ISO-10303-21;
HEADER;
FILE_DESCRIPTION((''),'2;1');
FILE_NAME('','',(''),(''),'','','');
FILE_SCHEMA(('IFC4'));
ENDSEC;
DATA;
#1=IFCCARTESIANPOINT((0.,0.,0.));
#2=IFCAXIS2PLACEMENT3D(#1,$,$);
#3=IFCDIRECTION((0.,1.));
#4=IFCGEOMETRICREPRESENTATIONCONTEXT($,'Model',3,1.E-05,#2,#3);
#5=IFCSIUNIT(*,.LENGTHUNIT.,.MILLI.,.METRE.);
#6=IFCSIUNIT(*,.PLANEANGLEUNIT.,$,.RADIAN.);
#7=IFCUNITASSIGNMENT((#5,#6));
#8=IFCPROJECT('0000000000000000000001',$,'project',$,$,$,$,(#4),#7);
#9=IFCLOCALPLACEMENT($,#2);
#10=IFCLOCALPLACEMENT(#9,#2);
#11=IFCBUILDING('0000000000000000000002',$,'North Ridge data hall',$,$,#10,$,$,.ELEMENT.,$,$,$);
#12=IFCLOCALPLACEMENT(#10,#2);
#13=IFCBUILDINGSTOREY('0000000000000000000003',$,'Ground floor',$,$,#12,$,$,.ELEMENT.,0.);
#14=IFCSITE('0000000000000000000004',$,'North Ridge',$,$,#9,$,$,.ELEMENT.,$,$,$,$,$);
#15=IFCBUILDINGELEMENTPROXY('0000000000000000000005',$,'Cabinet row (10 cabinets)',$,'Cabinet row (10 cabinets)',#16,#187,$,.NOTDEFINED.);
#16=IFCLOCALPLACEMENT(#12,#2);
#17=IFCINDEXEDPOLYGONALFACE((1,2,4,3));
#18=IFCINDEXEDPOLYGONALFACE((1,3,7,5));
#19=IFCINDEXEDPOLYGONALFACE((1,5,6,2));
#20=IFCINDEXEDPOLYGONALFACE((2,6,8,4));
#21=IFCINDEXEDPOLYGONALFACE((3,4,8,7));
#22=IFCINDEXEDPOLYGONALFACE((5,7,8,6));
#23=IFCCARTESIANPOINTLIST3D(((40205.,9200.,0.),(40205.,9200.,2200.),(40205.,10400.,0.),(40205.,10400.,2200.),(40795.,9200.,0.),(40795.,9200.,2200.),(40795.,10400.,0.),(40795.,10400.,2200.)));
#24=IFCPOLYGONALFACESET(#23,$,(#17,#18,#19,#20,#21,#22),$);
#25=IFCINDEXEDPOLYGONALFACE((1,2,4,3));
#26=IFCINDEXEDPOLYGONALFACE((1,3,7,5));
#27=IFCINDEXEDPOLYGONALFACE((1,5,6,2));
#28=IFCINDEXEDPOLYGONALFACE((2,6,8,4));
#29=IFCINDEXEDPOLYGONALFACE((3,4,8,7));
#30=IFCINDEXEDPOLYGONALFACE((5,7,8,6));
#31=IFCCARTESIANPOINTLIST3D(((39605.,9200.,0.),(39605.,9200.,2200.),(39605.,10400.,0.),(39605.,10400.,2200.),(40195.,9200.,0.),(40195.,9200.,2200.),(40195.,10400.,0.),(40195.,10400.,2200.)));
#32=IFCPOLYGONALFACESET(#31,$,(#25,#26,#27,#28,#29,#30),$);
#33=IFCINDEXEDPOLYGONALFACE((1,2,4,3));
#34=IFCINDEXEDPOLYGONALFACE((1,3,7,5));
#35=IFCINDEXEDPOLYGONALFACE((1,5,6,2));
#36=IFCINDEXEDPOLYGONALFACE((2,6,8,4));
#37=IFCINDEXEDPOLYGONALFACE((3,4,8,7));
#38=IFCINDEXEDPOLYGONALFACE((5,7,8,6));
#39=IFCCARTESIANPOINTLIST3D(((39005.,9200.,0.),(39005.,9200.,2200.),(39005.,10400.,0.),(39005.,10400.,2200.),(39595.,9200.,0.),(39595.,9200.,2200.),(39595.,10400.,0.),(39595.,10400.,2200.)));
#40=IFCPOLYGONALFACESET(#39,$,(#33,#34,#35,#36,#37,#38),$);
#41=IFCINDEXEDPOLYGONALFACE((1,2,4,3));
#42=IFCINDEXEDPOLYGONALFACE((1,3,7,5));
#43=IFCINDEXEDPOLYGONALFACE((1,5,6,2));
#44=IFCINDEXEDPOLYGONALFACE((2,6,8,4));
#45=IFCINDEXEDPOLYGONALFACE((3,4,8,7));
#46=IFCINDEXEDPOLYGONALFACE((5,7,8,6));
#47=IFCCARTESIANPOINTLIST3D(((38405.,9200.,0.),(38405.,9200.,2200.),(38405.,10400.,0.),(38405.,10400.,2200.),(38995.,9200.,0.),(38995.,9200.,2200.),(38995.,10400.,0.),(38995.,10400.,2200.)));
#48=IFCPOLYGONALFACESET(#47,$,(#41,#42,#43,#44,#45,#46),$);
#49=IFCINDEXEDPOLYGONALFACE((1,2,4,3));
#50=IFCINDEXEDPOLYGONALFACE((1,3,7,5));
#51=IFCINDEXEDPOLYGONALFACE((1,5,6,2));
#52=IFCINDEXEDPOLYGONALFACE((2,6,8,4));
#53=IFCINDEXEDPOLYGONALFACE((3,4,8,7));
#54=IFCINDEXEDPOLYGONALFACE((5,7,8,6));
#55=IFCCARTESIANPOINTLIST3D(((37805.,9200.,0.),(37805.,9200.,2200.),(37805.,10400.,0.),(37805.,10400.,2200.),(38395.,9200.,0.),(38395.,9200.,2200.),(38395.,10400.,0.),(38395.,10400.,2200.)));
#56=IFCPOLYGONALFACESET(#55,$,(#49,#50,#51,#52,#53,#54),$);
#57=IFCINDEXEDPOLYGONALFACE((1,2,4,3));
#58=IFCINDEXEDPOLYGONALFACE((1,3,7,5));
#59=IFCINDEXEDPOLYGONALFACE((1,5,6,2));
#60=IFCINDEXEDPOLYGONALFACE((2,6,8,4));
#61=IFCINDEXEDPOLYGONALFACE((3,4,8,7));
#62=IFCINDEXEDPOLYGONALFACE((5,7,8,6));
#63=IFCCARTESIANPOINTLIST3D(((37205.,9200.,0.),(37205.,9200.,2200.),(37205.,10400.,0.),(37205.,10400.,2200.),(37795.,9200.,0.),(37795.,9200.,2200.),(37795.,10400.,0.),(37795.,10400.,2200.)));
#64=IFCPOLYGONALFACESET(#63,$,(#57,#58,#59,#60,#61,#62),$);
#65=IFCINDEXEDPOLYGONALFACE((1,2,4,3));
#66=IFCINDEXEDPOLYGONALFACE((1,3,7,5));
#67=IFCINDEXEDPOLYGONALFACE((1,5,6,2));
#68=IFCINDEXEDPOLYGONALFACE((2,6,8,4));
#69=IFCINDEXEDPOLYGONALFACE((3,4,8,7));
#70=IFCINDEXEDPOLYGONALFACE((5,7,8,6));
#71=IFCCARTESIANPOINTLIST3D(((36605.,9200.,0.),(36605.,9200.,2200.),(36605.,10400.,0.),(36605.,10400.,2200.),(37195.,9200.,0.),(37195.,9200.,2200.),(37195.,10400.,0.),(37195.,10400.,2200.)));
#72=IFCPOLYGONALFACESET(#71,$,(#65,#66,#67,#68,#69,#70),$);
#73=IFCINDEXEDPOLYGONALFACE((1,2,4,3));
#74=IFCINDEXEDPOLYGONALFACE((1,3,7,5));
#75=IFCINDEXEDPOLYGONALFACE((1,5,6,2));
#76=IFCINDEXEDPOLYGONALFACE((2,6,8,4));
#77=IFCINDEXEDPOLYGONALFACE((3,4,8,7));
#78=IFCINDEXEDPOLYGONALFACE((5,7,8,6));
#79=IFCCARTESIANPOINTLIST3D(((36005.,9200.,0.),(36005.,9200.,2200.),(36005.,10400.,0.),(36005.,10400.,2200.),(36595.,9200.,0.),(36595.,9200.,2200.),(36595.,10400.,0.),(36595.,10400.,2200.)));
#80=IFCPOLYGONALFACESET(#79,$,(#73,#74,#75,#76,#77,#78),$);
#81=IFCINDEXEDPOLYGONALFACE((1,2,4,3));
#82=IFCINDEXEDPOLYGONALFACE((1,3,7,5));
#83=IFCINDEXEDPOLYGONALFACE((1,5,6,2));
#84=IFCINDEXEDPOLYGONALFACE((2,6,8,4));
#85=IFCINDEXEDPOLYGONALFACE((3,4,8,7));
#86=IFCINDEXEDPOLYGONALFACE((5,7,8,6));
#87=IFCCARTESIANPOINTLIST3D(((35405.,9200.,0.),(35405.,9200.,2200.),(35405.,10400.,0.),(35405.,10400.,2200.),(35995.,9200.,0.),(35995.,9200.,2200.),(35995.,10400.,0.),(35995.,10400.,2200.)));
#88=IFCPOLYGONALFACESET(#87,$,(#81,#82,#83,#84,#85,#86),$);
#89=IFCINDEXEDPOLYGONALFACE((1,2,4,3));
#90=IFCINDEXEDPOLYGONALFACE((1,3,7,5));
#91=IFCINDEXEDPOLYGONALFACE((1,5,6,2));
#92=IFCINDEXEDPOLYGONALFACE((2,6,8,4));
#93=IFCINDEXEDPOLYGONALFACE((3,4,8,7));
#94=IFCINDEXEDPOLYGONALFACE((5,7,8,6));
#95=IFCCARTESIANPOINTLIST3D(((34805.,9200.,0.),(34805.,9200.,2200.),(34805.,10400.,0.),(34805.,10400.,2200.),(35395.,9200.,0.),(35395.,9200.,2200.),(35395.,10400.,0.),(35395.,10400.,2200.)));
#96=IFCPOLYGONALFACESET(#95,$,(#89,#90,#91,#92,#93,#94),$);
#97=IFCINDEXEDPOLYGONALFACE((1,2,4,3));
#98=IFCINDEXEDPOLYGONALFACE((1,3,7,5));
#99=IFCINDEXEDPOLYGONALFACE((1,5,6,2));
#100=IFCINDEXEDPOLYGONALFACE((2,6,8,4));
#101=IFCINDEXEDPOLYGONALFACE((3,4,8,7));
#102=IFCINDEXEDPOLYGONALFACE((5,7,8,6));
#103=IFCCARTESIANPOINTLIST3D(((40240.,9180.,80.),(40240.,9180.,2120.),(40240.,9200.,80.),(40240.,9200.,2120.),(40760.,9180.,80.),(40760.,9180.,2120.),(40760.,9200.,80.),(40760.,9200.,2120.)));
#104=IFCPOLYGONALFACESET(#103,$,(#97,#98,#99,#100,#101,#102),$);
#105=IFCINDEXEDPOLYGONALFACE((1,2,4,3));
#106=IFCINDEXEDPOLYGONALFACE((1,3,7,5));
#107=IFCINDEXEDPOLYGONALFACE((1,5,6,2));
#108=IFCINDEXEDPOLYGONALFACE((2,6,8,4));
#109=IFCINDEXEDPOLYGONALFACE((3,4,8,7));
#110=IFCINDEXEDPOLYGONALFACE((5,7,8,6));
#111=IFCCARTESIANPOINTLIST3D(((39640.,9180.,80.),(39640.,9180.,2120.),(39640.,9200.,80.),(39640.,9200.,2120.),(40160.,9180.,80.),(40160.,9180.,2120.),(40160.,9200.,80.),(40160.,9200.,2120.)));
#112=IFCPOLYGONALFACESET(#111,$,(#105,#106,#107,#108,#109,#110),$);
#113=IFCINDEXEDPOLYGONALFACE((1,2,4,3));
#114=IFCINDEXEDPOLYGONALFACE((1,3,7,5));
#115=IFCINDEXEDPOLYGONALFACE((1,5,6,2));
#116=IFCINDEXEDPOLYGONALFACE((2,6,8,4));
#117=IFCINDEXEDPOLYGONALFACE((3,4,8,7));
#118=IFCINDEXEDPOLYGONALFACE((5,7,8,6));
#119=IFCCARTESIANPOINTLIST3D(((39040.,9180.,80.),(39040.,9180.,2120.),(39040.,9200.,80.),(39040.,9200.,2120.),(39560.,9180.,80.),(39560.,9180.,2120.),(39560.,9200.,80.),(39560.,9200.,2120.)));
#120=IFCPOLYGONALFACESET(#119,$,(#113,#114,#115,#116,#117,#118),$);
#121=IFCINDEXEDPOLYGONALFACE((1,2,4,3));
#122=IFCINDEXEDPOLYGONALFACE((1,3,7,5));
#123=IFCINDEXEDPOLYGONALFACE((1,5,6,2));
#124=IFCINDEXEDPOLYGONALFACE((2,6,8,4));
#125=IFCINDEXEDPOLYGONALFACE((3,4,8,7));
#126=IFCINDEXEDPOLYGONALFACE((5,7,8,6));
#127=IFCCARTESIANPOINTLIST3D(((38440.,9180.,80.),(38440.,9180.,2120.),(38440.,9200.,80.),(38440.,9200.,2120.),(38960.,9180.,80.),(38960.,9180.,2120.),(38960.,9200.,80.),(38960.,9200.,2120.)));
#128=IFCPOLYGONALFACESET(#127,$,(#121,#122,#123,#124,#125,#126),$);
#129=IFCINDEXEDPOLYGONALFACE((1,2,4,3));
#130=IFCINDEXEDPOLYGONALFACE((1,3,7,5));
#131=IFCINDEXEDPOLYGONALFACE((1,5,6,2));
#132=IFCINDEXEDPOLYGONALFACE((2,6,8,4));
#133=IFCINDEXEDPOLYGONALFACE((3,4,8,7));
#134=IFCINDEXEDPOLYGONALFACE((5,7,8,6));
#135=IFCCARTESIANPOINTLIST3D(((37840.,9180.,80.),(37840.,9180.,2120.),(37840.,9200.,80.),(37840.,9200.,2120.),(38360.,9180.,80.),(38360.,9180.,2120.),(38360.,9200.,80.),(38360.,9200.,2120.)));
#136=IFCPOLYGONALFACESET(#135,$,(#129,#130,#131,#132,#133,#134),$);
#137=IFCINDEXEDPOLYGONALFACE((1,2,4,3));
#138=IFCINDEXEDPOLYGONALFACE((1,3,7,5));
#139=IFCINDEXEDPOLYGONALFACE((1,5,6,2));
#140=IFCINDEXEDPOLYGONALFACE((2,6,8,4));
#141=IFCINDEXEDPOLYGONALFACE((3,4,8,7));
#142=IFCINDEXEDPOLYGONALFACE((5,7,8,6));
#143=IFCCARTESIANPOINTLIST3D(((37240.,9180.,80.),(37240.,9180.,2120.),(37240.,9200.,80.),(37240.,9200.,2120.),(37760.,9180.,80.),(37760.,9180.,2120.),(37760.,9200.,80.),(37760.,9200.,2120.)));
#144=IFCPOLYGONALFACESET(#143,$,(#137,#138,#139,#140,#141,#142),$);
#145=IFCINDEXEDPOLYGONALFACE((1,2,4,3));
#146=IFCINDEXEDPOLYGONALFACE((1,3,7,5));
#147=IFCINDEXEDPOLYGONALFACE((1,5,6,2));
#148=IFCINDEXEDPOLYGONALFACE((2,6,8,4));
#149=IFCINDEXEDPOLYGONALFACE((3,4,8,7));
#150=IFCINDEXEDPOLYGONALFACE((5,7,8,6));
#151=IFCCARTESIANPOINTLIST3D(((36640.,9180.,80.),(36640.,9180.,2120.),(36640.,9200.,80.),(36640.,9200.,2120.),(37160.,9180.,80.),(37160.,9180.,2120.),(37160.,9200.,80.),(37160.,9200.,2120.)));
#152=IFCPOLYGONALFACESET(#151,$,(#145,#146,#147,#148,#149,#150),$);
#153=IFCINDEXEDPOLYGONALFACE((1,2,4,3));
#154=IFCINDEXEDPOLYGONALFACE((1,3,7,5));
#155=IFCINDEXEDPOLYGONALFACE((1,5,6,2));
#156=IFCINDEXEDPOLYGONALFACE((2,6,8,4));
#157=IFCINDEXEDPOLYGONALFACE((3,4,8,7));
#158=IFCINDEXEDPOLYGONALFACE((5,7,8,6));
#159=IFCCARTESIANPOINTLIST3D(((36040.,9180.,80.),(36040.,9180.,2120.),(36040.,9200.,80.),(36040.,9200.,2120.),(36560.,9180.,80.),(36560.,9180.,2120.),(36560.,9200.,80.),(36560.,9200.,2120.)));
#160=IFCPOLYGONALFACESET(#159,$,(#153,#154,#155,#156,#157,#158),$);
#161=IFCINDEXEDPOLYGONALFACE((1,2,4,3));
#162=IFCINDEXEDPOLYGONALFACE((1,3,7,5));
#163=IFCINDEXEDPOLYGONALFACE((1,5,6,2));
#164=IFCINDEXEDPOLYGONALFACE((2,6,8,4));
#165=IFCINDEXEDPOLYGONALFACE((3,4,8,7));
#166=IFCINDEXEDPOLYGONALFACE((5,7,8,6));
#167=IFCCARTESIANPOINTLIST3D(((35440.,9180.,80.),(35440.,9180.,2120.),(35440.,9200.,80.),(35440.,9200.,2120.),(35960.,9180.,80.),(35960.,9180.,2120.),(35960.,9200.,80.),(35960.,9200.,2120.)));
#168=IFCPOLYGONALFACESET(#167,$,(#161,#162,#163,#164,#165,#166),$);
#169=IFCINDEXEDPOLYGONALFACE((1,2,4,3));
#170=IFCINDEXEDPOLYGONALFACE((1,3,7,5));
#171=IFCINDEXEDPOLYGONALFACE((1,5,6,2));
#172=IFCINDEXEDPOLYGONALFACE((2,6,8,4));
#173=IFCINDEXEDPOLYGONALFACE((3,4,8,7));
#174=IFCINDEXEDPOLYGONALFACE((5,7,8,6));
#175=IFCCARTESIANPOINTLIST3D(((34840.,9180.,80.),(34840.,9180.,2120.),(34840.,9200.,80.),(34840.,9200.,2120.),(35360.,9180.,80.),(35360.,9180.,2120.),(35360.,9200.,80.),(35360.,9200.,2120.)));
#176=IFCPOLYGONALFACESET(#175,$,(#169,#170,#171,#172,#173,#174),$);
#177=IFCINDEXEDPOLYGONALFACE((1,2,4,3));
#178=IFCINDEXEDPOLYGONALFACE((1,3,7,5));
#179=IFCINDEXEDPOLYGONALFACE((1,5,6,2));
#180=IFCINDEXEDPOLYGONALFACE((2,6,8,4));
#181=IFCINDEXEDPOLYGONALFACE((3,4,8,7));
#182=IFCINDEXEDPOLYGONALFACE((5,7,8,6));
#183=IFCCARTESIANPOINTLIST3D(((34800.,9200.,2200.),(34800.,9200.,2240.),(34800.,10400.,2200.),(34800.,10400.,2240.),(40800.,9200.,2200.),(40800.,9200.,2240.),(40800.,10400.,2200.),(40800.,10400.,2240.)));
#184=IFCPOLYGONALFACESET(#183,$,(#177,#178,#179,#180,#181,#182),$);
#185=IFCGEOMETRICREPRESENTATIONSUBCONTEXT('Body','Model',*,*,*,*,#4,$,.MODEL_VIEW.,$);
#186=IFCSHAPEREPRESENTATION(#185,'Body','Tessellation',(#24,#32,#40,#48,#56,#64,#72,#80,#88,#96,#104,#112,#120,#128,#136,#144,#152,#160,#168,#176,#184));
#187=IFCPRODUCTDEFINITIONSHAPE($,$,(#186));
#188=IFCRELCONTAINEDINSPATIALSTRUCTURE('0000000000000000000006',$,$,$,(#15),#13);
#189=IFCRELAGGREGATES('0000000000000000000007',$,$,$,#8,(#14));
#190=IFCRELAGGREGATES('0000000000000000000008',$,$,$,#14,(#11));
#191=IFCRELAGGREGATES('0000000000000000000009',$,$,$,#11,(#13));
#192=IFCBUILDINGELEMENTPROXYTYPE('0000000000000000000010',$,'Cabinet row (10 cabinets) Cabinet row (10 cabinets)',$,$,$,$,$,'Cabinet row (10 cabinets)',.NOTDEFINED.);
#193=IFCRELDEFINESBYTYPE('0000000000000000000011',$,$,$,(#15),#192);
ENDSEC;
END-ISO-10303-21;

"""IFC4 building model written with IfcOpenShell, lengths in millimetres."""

from ifc_helpers import new_model, si_unit, direction, frame, origin, place, context, subcontext, project, spatial, polyline, outline, extrude, source, transform, mapped, type_object, type_shapes, element, save


model = new_model("IFC4")

# Units and contexts
model_context = context("Model", 3, precision=1e-05, world=origin(), true_north=direction((0.0, 1.0)))
body_context = subcontext(model_context, "Body", "Model", "MODEL_VIEW")
ifc_project = project(units=[si_unit("LENGTHUNIT", "METRE", prefix="MILLI"), si_unit("PLANEANGLEUNIT", "RADIAN")], contexts=[model_context])

# Site, building, storey
site_placement = place(None, origin())
site = spatial("IfcSite", under=ifc_project, at=site_placement, Name="North Ridge", CompositionType="ELEMENT")
building_placement = place(site_placement, origin())
building = spatial("IfcBuilding", under=site, at=building_placement, Name="North Ridge data hall", CompositionType="ELEMENT")
storey_placement = place(building_placement, origin())
storey = spatial("IfcBuildingStorey", under=building, at=storey_placement, Name="Ground floor", CompositionType="ELEMENT", Elevation=0.0)

# Building element proxy
building_element_proxy_type_1 = type_object("IfcBuildingElementProxyType", Name="Cabinet row (10 cabinets) Cabinet row (10 cabinets)", ElementType="Cabinet row (10 cabinets)", PredefinedType="NOTDEFINED")
shared_shape_1 = source(origin(), body_context, "Body", "SweptSolid", [
    extrude(outline(polyline([(5.0, 0.0), (595.0, 0.0), (595.0, 1200.0), (5.0, 1200.0), (5.0, 0.0)])), origin(), (0.0, 0.0, 1.0), 2200.0),
    extrude(outline(polyline([(605.0, 0.0), (1195.0, 0.0), (1195.0, 1200.0), (605.0, 1200.0), (605.0, 0.0)])), origin(), (0.0, 0.0, 1.0), 2200.0),
    extrude(outline(polyline([(1205.0, 0.0), (1795.0, 0.0), (1795.0, 1200.0), (1205.0, 1200.0), (1205.0, 0.0)])), origin(), (0.0, 0.0, 1.0), 2200.0),
    extrude(outline(polyline([(1805.0, 0.0), (2395.0, 0.0), (2395.0, 1200.0), (1805.0, 1200.0), (1805.0, 0.0)])), origin(), (0.0, 0.0, 1.0), 2200.0),
    extrude(outline(polyline([(2405.0, 0.0), (2995.0, 0.0), (2995.0, 1200.0), (2405.0, 1200.0), (2405.0, 0.0)])), origin(), (0.0, 0.0, 1.0), 2200.0),
    extrude(outline(polyline([(3005.0, 0.0), (3595.0, 0.0), (3595.0, 1200.0), (3005.0, 1200.0), (3005.0, 0.0)])), origin(), (0.0, 0.0, 1.0), 2200.0),
    extrude(outline(polyline([(3605.0, 0.0), (4195.0, 0.0), (4195.0, 1200.0), (3605.0, 1200.0), (3605.0, 0.0)])), origin(), (0.0, 0.0, 1.0), 2200.0),
    extrude(outline(polyline([(4205.0, 0.0), (4795.0, 0.0), (4795.0, 1200.0), (4205.0, 1200.0), (4205.0, 0.0)])), origin(), (0.0, 0.0, 1.0), 2200.0),
    extrude(outline(polyline([(4805.0, 0.0), (5395.0, 0.0), (5395.0, 1200.0), (4805.0, 1200.0), (4805.0, 0.0)])), origin(), (0.0, 0.0, 1.0), 2200.0),
    extrude(outline(polyline([(5405.0, 0.0), (5995.0, 0.0), (5995.0, 1200.0), (5405.0, 1200.0), (5405.0, 0.0)])), origin(), (0.0, 0.0, 1.0), 2200.0),
    extrude(outline(polyline([(40.0, 1200.0), (560.0, 1200.0), (560.0, 1220.0), (40.0, 1220.0), (40.0, 1200.0)])), frame((0.0, 0.0, 80.0)), (0.0, 0.0, 1.0), 2040.0),
    extrude(outline(polyline([(640.0, 1200.0), (1160.0, 1200.0), (1160.0, 1220.0), (640.0, 1220.0), (640.0, 1200.0)])), frame((0.0, 0.0, 80.0)), (0.0, 0.0, 1.0), 2040.0),
    extrude(outline(polyline([(1240.0, 1200.0), (1760.0, 1200.0), (1760.0, 1220.0), (1240.0, 1220.0), (1240.0, 1200.0)])), frame((0.0, 0.0, 80.0)), (0.0, 0.0, 1.0), 2040.0),
    extrude(outline(polyline([(1840.0, 1200.0), (2360.0, 1200.0), (2360.0, 1220.0), (1840.0, 1220.0), (1840.0, 1200.0)])), frame((0.0, 0.0, 80.0)), (0.0, 0.0, 1.0), 2040.0),
    extrude(outline(polyline([(2440.0, 1200.0), (2960.0, 1200.0), (2960.0, 1220.0), (2440.0, 1220.0), (2440.0, 1200.0)])), frame((0.0, 0.0, 80.0)), (0.0, 0.0, 1.0), 2040.0),
    extrude(outline(polyline([(3040.0, 1200.0), (3560.0, 1200.0), (3560.0, 1220.0), (3040.0, 1220.0), (3040.0, 1200.0)])), frame((0.0, 0.0, 80.0)), (0.0, 0.0, 1.0), 2040.0),
    extrude(outline(polyline([(3640.0, 1200.0), (4160.0, 1200.0), (4160.0, 1220.0), (3640.0, 1220.0), (3640.0, 1200.0)])), frame((0.0, 0.0, 80.0)), (0.0, 0.0, 1.0), 2040.0),
    extrude(outline(polyline([(4240.0, 1200.0), (4760.0, 1200.0), (4760.0, 1220.0), (4240.0, 1220.0), (4240.0, 1200.0)])), frame((0.0, 0.0, 80.0)), (0.0, 0.0, 1.0), 2040.0),
    extrude(outline(polyline([(4840.0, 1200.0), (5360.0, 1200.0), (5360.0, 1220.0), (4840.0, 1220.0), (4840.0, 1200.0)])), frame((0.0, 0.0, 80.0)), (0.0, 0.0, 1.0), 2040.0),
    extrude(outline(polyline([(5440.0, 1200.0), (5960.0, 1200.0), (5960.0, 1220.0), (5440.0, 1220.0), (5440.0, 1200.0)])), frame((0.0, 0.0, 80.0)), (0.0, 0.0, 1.0), 2040.0),
    extrude(outline(polyline([(0.0, 0.0), (6000.0, 0.0), (6000.0, 1200.0), (0.0, 1200.0), (0.0, 0.0)])), frame((0.0, 0.0, 2200.0)), (0.0, 0.0, 1.0), 40.0),
])
type_shapes(building_element_proxy_type_1, [shared_shape_1])
for number, where, z_axis, x_axis, name in (
    (1, (40800.0, 10400.0, 0.0), (0.0, 0.0, 1.0), (-1.0, 0.0, 0.0), "Cabinet row (10 cabinets)"),
):
    element("IfcBuildingElementProxy", number, at=place(storey_placement, frame(where, z_axis=z_axis, x_axis=x_axis)), inside=storey, type_object=building_element_proxy_type_1, Name=name, ObjectType="Cabinet row (10 cabinets)", PredefinedType="NOTDEFINED", context=body_context, shape_type="MappedRepresentation", body=[
        mapped(shared_shape_1, transform((0.0, 0.0, 0.0))),
    ])

save(model, "model.ifc")
